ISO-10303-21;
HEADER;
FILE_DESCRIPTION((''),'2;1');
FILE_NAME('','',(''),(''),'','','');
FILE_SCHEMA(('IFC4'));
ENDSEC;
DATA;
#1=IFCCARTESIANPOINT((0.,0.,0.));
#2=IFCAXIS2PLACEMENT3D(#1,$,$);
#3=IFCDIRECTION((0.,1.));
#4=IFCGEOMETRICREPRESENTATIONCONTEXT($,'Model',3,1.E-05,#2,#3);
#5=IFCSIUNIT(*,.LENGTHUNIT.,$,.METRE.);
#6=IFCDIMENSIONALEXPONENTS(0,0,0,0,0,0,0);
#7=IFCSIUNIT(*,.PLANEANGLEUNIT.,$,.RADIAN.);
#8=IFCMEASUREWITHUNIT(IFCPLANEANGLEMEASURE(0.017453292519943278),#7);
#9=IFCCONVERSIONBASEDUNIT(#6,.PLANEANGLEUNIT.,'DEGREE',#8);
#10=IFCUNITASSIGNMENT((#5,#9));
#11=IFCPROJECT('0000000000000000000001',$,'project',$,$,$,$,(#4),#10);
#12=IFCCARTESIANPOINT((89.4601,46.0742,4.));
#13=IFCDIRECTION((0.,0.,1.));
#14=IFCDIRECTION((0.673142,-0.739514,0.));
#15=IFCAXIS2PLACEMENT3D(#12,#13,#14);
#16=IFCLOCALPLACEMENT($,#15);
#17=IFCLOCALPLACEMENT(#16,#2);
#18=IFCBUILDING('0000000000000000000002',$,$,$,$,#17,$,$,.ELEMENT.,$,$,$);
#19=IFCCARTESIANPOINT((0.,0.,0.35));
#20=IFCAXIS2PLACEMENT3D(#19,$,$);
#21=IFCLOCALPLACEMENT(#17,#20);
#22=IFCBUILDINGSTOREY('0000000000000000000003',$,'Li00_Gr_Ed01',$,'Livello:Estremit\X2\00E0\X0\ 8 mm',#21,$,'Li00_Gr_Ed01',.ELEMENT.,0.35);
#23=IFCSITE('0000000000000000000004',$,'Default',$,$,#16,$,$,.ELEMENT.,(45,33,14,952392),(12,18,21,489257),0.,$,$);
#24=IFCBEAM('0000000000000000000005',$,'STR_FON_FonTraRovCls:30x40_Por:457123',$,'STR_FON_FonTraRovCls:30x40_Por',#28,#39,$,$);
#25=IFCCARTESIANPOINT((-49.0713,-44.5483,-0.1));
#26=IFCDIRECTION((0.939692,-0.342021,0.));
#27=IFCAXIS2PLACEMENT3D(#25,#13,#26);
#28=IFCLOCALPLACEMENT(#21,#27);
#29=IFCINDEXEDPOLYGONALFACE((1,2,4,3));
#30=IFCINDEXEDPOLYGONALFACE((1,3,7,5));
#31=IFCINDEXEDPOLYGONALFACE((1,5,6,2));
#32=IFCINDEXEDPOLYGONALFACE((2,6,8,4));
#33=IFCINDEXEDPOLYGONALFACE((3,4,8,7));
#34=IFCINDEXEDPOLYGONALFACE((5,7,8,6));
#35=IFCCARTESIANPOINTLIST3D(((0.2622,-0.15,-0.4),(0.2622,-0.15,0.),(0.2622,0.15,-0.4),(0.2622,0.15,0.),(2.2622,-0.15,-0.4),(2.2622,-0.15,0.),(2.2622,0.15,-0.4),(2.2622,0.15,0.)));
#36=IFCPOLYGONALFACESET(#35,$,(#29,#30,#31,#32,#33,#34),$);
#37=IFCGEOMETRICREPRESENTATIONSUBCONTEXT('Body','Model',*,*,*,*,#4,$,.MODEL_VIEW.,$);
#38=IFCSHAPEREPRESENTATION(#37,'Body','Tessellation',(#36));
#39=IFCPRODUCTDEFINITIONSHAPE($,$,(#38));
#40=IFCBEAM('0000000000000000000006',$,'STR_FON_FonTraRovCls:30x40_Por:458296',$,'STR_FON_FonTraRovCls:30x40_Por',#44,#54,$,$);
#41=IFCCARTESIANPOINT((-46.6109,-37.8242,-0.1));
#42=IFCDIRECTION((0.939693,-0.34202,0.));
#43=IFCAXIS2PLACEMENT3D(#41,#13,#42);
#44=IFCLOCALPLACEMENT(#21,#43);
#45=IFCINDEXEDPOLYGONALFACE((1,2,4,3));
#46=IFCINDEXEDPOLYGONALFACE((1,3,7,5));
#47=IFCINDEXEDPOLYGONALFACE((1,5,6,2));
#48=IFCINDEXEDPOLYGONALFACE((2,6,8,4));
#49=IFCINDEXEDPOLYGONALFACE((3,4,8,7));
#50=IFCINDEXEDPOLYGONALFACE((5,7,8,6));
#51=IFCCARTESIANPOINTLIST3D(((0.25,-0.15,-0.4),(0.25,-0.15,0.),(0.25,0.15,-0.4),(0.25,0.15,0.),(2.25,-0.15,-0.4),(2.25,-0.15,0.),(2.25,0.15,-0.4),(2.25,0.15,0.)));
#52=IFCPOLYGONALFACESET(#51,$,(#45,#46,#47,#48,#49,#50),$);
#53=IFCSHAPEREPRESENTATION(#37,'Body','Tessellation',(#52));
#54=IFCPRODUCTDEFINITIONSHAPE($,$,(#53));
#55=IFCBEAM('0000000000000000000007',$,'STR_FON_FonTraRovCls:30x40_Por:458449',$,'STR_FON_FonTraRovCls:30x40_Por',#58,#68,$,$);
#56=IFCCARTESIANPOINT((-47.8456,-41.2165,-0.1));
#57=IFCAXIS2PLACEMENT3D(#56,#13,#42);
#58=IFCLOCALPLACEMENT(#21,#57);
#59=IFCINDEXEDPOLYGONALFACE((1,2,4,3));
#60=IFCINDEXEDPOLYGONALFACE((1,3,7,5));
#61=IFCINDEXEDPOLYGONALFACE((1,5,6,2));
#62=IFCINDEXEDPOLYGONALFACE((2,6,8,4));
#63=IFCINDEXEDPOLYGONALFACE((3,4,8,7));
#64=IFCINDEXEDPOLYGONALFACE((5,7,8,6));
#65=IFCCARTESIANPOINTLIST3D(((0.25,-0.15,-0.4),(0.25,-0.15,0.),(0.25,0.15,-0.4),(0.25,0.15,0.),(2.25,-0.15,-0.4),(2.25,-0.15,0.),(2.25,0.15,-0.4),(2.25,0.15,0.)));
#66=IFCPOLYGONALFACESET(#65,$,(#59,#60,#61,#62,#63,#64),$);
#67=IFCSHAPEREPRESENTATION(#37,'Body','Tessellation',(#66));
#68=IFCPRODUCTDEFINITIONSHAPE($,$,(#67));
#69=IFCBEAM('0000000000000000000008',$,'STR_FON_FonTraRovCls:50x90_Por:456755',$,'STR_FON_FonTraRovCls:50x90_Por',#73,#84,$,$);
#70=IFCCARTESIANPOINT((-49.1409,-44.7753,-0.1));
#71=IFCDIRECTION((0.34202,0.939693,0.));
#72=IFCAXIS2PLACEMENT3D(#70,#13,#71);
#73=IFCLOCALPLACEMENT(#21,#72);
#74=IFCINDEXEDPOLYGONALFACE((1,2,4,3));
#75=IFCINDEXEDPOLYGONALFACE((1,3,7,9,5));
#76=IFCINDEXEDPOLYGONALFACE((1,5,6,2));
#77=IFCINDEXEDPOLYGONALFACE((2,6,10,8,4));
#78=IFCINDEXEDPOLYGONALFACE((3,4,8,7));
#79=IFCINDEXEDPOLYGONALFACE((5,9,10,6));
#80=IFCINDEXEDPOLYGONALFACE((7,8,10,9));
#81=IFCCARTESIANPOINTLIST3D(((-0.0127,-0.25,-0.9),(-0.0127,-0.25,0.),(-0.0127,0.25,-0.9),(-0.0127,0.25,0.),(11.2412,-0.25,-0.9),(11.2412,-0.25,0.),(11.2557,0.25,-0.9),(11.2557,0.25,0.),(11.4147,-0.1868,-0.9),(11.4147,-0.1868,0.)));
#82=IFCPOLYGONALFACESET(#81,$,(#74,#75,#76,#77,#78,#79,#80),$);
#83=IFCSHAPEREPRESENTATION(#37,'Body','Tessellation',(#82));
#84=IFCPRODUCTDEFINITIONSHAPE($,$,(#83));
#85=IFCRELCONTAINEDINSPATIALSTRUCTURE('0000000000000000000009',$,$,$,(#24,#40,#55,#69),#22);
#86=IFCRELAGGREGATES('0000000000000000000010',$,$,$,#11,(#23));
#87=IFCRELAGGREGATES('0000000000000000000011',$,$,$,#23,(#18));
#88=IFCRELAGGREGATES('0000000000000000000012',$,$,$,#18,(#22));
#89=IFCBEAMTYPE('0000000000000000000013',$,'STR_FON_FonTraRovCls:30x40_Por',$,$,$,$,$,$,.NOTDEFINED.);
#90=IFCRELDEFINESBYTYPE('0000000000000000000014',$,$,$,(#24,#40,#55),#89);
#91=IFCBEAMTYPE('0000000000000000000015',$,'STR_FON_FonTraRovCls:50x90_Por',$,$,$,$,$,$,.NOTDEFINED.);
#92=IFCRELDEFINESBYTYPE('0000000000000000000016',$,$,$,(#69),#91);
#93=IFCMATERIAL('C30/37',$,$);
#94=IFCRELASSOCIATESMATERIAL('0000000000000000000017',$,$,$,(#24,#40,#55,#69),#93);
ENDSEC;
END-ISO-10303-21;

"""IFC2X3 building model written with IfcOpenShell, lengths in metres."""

from ifc_helpers import new_model, entity, si_unit, converted_unit, direction, frame, frame_2d, origin, place, context, subcontext, project, spatial, rectangle, extrude, clip, halfspace, material, type_object, element, save


model = new_model("IFC2X3")

# Units and contexts
model_context = context("Model", 3, precision=1e-05, world=origin(), true_north=direction((0.0, 1.0)))
body_context = subcontext(model_context, "Body", "Model", "MODEL_VIEW")
ifc_project = project(units=[si_unit("LENGTHUNIT", "METRE"), converted_unit("PLANEANGLEUNIT", "DEGREE", entity("IfcPlaneAngleMeasure", 0.017453292519943278), si_unit("PLANEANGLEUNIT", "RADIAN"), dimensions=[0, 0, 0, 0, 0, 0, 0])], contexts=[model_context])

# Site, building, storey
site_placement = place(None, frame((89.4601, 46.0742, 4.0), z_axis=(0.0, 0.0, 1.0), x_axis=(0.673142, -0.739514, 0.0)))
site = spatial("IfcSite", under=ifc_project, at=site_placement, Name="Default", CompositionType="ELEMENT", RefLatitude=(45, 33, 14, 952392), RefLongitude=(12, 18, 21, 489257), RefElevation=0.0)
building_placement = place(site_placement, origin())
building = spatial("IfcBuilding", under=site, at=building_placement, CompositionType="ELEMENT")
storey_placement = place(building_placement, frame((0.0, 0.0, 0.35)))
storey = spatial("IfcBuildingStorey", under=building, at=storey_placement, Name="Li00_Gr_Ed01", ObjectType="Livello:Estremità 8 mm", LongName="Li00_Gr_Ed01", CompositionType="ELEMENT", Elevation=0.35)

# Beams
ifc_material_1 = material(Name="C30/37")
beam_type_1 = type_object("IfcBeamType", Name="STR_FON_FonTraRovCls:30x40_Por", PredefinedType="NOTDEFINED")
beam_1_placement = place(storey_placement, frame((-49.0713, -44.5483, -0.1), z_axis=(0.0, 0.0, 1.0), x_axis=(0.939692, -0.342021, 0.0)))
element("IfcBeam", 1, at=beam_1_placement, inside=storey, type_object=beam_type_1, material=ifc_material_1, Name="STR_FON_FonTraRovCls:30x40_Por:457123", ObjectType="STR_FON_FonTraRovCls:30x40_Por", context=body_context, shape_type="SweptSolid", body=[
    extrude(rectangle(XDim=0.4, YDim=0.3, at=frame_2d((0.0, 0.0), x_axis=(1.0, 0.0))), frame((0.2622, 0.0, -0.2), z_axis=(1.0, 0.0, 0.0), x_axis=(0.0, 0.0, -1.0)), (0.0, 0.0, 1.0), 2.0),
])
beam_2_placement = place(storey_placement, frame((-46.6109, -37.8242, -0.1), z_axis=(0.0, 0.0, 1.0), x_axis=(0.939693, -0.34202, 0.0)))
element("IfcBeam", 2, at=beam_2_placement, inside=storey, type_object=beam_type_1, material=ifc_material_1, Name="STR_FON_FonTraRovCls:30x40_Por:458296", ObjectType="STR_FON_FonTraRovCls:30x40_Por", context=body_context, shape_type="SweptSolid", body=[
    extrude(rectangle(XDim=0.4, YDim=0.3, at=frame_2d((0.0, 0.0), x_axis=(1.0, 0.0))), frame((0.25, 0.0, -0.2), z_axis=(1.0, 0.0, 0.0), x_axis=(0.0, 0.0, -1.0)), (0.0, 0.0, 1.0), 2.0),
])
beam_3_placement = place(storey_placement, frame((-47.8456, -41.2165, -0.1), z_axis=(0.0, 0.0, 1.0), x_axis=(0.939693, -0.34202, 0.0)))
element("IfcBeam", 3, at=beam_3_placement, inside=storey, type_object=beam_type_1, material=ifc_material_1, Name="STR_FON_FonTraRovCls:30x40_Por:458449", ObjectType="STR_FON_FonTraRovCls:30x40_Por", context=body_context, shape_type="SweptSolid", body=[
    extrude(rectangle(XDim=0.4, YDim=0.3, at=frame_2d((0.0, 0.0), x_axis=(1.0, 0.0))), frame((0.25, 0.0, -0.2), z_axis=(1.0, 0.0, 0.0), x_axis=(0.0, 0.0, -1.0)), (0.0, 0.0, 1.0), 2.0),
])
beam_type_2 = type_object("IfcBeamType", Name="STR_FON_FonTraRovCls:50x90_Por", PredefinedType="NOTDEFINED")
beam_4_placement = place(storey_placement, frame((-49.1409, -44.7753, -0.1), z_axis=(0.0, 0.0, 1.0), x_axis=(0.34202, 0.939693, 0.0)))
element("IfcBeam", 4, at=beam_4_placement, inside=storey, type_object=beam_type_2, material=ifc_material_1, Name="STR_FON_FonTraRovCls:50x90_Por:456755", ObjectType="STR_FON_FonTraRovCls:50x90_Por", context=body_context, shape_type="SweptSolid", body=[
    clip(clip(extrude(rectangle(XDim=0.9, YDim=0.5, at=frame_2d((0.0, 0.0), x_axis=(1.0, 0.0))), frame((-0.0127, 0.0, -0.45), z_axis=(1.0, 0.0, 0.0), x_axis=(0.0, 0.0, -1.0)), (0.0, 0.0, 1.0), 11.4274), halfspace(frame((11.3292, 0.0481, -0.45), z_axis=(0.939693, 0.34202, 0.0), x_axis=(0.0, 0.0, 1.0)), False)), halfspace(frame((10.1859, -0.6341, -0.9), z_axis=(0.34202, -0.939693, 0.0), x_axis=(0.939693, 0.34202, 0.0)), False)),
])

save(model, "model.ifc")
